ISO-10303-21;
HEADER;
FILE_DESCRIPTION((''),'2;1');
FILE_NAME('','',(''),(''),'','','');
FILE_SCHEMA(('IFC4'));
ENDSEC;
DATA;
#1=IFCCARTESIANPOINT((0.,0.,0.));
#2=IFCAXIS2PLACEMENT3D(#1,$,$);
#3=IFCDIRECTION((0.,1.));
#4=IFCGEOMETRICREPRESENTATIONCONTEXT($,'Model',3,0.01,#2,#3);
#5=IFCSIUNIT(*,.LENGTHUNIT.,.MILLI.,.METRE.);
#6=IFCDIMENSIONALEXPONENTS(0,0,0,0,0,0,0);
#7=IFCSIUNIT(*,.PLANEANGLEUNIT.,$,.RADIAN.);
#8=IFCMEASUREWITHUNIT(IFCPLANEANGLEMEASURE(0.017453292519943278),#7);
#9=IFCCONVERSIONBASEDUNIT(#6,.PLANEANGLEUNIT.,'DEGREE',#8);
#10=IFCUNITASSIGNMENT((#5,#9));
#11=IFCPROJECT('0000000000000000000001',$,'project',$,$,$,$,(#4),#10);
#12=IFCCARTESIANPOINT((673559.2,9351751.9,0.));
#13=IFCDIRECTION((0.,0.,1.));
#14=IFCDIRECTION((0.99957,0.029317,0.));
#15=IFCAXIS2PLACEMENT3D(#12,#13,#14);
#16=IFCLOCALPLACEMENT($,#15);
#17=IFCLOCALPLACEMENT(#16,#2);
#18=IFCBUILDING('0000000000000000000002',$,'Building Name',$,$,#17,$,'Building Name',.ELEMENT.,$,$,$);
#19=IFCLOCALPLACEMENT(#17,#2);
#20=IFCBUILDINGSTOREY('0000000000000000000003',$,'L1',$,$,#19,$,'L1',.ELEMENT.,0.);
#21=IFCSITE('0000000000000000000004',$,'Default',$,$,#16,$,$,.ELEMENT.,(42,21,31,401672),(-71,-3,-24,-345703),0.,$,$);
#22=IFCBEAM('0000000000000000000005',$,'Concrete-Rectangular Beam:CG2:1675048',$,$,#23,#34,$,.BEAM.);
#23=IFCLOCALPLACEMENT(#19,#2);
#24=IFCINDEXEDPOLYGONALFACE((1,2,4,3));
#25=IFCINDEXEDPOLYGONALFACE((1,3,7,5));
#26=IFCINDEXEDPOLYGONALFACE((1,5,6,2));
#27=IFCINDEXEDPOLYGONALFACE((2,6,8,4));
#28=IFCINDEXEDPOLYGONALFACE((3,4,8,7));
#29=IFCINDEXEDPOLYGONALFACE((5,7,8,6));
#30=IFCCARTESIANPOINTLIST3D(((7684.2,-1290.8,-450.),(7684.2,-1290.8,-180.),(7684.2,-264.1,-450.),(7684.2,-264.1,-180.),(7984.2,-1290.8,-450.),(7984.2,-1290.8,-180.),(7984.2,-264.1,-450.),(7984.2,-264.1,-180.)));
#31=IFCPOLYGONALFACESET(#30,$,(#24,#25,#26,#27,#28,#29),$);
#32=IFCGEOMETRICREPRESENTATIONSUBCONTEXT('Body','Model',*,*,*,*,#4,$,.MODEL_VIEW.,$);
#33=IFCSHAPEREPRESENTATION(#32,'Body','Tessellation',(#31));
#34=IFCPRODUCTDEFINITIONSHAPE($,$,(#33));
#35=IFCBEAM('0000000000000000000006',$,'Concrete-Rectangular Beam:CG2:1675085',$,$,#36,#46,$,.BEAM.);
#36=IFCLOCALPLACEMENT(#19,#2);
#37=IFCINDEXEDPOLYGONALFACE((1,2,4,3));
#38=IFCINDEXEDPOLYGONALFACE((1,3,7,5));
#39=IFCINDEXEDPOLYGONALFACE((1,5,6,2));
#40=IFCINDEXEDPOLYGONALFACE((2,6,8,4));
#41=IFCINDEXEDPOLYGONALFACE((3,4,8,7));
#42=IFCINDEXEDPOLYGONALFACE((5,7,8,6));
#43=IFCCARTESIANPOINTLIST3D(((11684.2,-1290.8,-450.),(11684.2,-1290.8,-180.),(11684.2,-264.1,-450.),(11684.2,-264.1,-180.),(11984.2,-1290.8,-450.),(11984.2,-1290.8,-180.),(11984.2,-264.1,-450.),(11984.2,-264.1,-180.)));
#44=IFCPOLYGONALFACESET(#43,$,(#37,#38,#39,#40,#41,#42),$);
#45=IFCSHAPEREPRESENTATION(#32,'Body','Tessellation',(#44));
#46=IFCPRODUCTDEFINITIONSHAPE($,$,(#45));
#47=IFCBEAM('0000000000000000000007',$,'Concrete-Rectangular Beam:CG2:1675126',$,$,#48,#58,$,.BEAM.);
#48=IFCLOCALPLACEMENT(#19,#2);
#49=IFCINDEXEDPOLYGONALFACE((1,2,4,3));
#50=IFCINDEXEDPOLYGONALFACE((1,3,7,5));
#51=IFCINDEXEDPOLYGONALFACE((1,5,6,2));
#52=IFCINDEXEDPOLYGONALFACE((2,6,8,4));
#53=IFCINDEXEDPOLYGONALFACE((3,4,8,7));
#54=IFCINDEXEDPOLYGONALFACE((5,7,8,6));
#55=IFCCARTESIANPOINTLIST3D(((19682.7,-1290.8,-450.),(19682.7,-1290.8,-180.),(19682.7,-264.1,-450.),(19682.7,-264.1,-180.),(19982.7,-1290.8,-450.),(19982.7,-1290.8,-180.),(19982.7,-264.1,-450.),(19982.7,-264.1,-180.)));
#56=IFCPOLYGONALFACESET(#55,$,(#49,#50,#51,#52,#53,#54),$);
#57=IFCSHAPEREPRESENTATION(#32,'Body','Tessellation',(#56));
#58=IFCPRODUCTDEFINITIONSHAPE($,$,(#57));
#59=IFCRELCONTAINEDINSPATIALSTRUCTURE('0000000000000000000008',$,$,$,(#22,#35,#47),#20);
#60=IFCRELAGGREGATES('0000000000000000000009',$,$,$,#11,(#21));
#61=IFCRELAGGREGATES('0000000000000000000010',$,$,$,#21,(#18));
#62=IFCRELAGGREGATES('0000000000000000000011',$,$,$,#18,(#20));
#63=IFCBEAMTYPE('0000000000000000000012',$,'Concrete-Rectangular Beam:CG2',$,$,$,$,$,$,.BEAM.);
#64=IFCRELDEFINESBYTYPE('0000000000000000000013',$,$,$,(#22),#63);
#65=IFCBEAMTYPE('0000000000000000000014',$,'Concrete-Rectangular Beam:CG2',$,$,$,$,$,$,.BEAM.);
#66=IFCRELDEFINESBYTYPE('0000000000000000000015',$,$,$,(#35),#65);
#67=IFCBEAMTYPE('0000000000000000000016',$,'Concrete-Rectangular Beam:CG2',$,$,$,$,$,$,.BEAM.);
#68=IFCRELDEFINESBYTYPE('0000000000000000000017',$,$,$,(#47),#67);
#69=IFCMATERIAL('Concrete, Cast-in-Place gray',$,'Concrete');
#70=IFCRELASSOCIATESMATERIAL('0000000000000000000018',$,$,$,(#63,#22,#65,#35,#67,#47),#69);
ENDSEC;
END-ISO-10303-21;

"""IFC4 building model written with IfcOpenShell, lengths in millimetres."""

from ifc_helpers import new_model, entity, si_unit, converted_unit, direction, frame, origin, place, context, subcontext, project, spatial, indexed_curve, outline, extrude, source, transform, mapped, material, type_object, type_shapes, element, save


model = new_model("IFC4")

# Units and contexts
model_context = context("Model", 3, precision=0.01, world=origin(), true_north=direction((0.0, 1.0)))
body_context = subcontext(model_context, "Body", "Model", "MODEL_VIEW")
ifc_project = project(units=[si_unit("LENGTHUNIT", "METRE", prefix="MILLI"), converted_unit("PLANEANGLEUNIT", "DEGREE", entity("IfcPlaneAngleMeasure", 0.017453292519943278), si_unit("PLANEANGLEUNIT", "RADIAN"), dimensions=[0, 0, 0, 0, 0, 0, 0])], contexts=[model_context])

# Site, building, storey
site_placement = place(None, frame((673559.2, 9351751.9, 0.0), z_axis=(0.0, 0.0, 1.0), x_axis=(0.99957, 0.029317, 0.0)))
site = spatial("IfcSite", under=ifc_project, at=site_placement, Name="Default", CompositionType="ELEMENT", RefLatitude=(42, 21, 31, 401672), RefLongitude=(-71, -3, -24, -345703), RefElevation=0.0)
building_placement = place(site_placement, origin())
building = spatial("IfcBuilding", under=site, at=building_placement, Name="Building Name", LongName="Building Name", CompositionType="ELEMENT")
storey_placement = place(building_placement, origin())
storey = spatial("IfcBuildingStorey", under=building, at=storey_placement, Name="L1", LongName="L1", CompositionType="ELEMENT", Elevation=0.0)

# Beams
ifc_material = material(Name="Concrete, Cast-in-Place gray", Category="Concrete")
beam_type_1 = type_object("IfcBeamType", Name="Concrete-Rectangular Beam:CG2", PredefinedType="BEAM", material=ifc_material)
shared_shape_1 = source(origin(), body_context, "Body", "SweptSolid", [
    extrude(outline(indexed_curve([(-150.0, -135.0), (150.0, -135.0), (150.0, 135.0), (-150.0, 135.0), (-150.0, -135.0)], self_intersect=False)), frame((7834.2, -1290.8, -315.0), z_axis=(0.0, 1.0, 0.0), x_axis=(-1.0, 0.0, 0.0)), (0.0, 0.0, 1.0), 1026.7),
])
type_shapes(beam_type_1, [shared_shape_1])
beam_1_placement = place(storey_placement, origin())
element("IfcBeam", 1, at=beam_1_placement, inside=storey, type_object=beam_type_1, material=ifc_material, Name="Concrete-Rectangular Beam:CG2:1675048", PredefinedType="BEAM", context=body_context, shape_type="MappedRepresentation", body=[
    mapped(shared_shape_1, transform((0.0, 0.0, 0.0), scale=1.0)),
])
beam_type_2 = type_object("IfcBeamType", Name="Concrete-Rectangular Beam:CG2", PredefinedType="BEAM", material=ifc_material)
shared_shape_2 = source(origin(), body_context, "Body", "SweptSolid", [
    extrude(outline(indexed_curve([(-150.0, -135.0), (150.0, -135.0), (150.0, 135.0), (-150.0, 135.0), (-150.0, -135.0)], self_intersect=False)), frame((11834.2, -1290.8, -315.0), z_axis=(0.0, 1.0, 0.0), x_axis=(-1.0, 0.0, 0.0)), (0.0, 0.0, 1.0), 1026.7),
])
type_shapes(beam_type_2, [shared_shape_2])
beam_2_placement = place(storey_placement, origin())
element("IfcBeam", 2, at=beam_2_placement, inside=storey, type_object=beam_type_2, material=ifc_material, Name="Concrete-Rectangular Beam:CG2:1675085", PredefinedType="BEAM", context=body_context, shape_type="MappedRepresentation", body=[
    mapped(shared_shape_2, transform((0.0, 0.0, 0.0), scale=1.0)),
])
beam_type_3 = type_object("IfcBeamType", Name="Concrete-Rectangular Beam:CG2", PredefinedType="BEAM", material=ifc_material)
shared_shape_3 = source(origin(), body_context, "Body", "SweptSolid", [
    extrude(outline(indexed_curve([(-150.0, -135.0), (150.0, -135.0), (150.0, 135.0), (-150.0, 135.0), (-150.0, -135.0)], self_intersect=False)), frame((19832.7, -1290.8, -315.0), z_axis=(0.0, 1.0, 0.0), x_axis=(-1.0, 0.0, 0.0)), (0.0, 0.0, 1.0), 1026.7),
])
type_shapes(beam_type_3, [shared_shape_3])
beam_3_placement = place(storey_placement, origin())
element("IfcBeam", 3, at=beam_3_placement, inside=storey, type_object=beam_type_3, material=ifc_material, Name="Concrete-Rectangular Beam:CG2:1675126", PredefinedType="BEAM", context=body_context, shape_type="MappedRepresentation", body=[
    mapped(shared_shape_3, transform((0.0, 0.0, 0.0), scale=1.0)),
])

save(model, "model.ifc")
